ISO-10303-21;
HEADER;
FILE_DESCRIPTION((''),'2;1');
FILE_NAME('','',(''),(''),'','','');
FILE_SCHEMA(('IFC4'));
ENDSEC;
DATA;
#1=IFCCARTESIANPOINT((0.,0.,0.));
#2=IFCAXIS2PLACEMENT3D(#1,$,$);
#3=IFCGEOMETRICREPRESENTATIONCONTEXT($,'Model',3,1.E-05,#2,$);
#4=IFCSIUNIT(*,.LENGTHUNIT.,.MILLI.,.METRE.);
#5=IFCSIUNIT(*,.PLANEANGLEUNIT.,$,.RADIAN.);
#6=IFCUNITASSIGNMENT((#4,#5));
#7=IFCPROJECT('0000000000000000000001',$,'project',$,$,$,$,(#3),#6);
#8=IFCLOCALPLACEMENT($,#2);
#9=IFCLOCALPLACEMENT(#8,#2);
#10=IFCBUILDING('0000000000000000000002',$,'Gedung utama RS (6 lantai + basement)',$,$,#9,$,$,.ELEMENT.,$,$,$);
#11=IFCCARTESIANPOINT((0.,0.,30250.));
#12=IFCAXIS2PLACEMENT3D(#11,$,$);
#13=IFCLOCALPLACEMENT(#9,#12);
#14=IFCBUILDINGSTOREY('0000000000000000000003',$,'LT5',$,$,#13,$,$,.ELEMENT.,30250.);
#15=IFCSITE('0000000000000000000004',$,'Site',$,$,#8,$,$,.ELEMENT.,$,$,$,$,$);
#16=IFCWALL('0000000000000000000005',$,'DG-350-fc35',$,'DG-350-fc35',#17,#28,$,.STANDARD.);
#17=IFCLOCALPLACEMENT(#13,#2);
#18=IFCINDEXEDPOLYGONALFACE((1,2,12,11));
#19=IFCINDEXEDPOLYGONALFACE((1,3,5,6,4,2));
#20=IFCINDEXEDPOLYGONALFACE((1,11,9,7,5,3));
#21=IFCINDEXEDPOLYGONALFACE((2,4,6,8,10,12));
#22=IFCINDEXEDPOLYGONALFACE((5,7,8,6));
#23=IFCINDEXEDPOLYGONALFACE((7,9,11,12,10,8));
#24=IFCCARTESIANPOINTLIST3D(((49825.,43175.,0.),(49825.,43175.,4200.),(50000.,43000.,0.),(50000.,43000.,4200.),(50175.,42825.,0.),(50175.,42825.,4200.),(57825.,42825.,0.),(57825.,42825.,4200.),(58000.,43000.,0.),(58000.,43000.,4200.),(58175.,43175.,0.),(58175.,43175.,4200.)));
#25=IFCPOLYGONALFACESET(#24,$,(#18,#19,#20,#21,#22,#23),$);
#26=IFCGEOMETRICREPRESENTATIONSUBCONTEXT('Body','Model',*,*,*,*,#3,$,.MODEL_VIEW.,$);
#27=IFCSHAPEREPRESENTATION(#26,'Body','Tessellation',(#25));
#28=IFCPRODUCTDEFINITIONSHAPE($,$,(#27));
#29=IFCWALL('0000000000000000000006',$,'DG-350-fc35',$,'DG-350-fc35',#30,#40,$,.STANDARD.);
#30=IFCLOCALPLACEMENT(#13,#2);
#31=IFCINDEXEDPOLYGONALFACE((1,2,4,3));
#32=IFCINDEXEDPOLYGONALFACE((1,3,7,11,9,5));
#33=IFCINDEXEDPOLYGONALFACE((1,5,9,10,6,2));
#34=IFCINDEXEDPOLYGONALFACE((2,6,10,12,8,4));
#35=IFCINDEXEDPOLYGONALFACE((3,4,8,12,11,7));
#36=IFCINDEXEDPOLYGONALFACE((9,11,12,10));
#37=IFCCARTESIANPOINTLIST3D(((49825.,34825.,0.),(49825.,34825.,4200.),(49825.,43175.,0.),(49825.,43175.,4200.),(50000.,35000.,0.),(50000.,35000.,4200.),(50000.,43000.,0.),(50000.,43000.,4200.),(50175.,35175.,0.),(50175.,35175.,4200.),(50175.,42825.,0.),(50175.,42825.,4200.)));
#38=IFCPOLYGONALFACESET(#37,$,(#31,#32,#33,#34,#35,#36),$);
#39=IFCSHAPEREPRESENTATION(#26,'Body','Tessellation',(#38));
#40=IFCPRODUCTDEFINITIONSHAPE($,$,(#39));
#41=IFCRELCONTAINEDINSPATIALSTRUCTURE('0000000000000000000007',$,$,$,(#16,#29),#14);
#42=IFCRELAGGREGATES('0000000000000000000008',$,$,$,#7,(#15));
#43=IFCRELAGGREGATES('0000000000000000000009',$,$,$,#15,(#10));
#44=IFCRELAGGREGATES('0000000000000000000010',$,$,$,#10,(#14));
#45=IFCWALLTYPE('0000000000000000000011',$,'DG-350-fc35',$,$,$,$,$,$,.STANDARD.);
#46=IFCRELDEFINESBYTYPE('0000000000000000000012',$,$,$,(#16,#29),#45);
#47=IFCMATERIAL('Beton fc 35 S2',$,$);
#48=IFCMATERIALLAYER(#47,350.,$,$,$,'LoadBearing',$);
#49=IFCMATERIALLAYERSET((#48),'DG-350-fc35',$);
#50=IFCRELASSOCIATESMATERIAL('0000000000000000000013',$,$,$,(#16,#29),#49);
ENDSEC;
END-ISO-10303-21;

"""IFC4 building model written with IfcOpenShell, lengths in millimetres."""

from ifc_helpers import new_model, si_unit, frame, origin, place, context, subcontext, project, spatial, polyline, outline, extrude, material, layer, layer_set, layer_usage, type_object, element, save


model = new_model("IFC4")

# Units and contexts
model_context = context("Model", 3, precision=1e-05, world=origin())
body_context = subcontext(model_context, "Body", "Model", "MODEL_VIEW")
ifc_project = project(units=[si_unit("LENGTHUNIT", "METRE", prefix="MILLI"), si_unit("PLANEANGLEUNIT", "RADIAN")], contexts=[model_context])

# Site, building, storey
site_placement = place(None, origin())
site = spatial("IfcSite", under=ifc_project, at=site_placement, Name="Site", CompositionType="ELEMENT")
building_placement = place(site_placement, origin())
building = spatial("IfcBuilding", under=site, at=building_placement, Name="Gedung utama RS (6 lantai + basement)", CompositionType="ELEMENT")
storey_placement = place(building_placement, frame((0.0, 0.0, 30250.0)))
storey = spatial("IfcBuildingStorey", under=building, at=storey_placement, Name="LT5", CompositionType="ELEMENT", Elevation=30250.0)

# Shared definitions
ifc_material_1 = material(Name="Beton fc 35 S2")
ifc_layer = layer(ifc_material_1, 350.0, Category="LoadBearing")
ifc_layer_set = layer_set([ifc_layer], Name="DG-350-fc35")
ifc_layer_usage = layer_usage(ifc_layer_set, "AXIS2", "NEGATIVE", 175.0)
wall_type = type_object("IfcWallType", Name="DG-350-fc35", PredefinedType="STANDARD")

# Walls
for number, where, z_axis, x_axis, name in (
    (1, (58000.0, 43000.0, 0.0), (0.0, 0.0, 1.0), (-1.0, 0.0, 0.0), "DG-350-fc35"),
    (2, (50000.0, 43000.0, 0.0), (0.0, 0.0, 1.0), (0.0, -1.0, 0.0), "DG-350-fc35"),
):
    element("IfcWall", number, at=place(storey_placement, frame(where, z_axis=z_axis, x_axis=x_axis)), inside=storey, type_object=wall_type, material=ifc_layer_usage, Name=name, ObjectType="DG-350-fc35", PredefinedType="STANDARD", context=body_context, shape_type="SweptSolid", body=[
        extrude(outline(polyline([(-175.0, -175.0), (0.0, 0.0), (175.0, 175.0), (7825.0, 175.0), (8000.0, 0.0), (8175.0, -175.0), (-175.0, -175.0)])), origin(), (0.0, 0.0, 1.0), 4200.0),
    ])

save(model, "model.ifc")
